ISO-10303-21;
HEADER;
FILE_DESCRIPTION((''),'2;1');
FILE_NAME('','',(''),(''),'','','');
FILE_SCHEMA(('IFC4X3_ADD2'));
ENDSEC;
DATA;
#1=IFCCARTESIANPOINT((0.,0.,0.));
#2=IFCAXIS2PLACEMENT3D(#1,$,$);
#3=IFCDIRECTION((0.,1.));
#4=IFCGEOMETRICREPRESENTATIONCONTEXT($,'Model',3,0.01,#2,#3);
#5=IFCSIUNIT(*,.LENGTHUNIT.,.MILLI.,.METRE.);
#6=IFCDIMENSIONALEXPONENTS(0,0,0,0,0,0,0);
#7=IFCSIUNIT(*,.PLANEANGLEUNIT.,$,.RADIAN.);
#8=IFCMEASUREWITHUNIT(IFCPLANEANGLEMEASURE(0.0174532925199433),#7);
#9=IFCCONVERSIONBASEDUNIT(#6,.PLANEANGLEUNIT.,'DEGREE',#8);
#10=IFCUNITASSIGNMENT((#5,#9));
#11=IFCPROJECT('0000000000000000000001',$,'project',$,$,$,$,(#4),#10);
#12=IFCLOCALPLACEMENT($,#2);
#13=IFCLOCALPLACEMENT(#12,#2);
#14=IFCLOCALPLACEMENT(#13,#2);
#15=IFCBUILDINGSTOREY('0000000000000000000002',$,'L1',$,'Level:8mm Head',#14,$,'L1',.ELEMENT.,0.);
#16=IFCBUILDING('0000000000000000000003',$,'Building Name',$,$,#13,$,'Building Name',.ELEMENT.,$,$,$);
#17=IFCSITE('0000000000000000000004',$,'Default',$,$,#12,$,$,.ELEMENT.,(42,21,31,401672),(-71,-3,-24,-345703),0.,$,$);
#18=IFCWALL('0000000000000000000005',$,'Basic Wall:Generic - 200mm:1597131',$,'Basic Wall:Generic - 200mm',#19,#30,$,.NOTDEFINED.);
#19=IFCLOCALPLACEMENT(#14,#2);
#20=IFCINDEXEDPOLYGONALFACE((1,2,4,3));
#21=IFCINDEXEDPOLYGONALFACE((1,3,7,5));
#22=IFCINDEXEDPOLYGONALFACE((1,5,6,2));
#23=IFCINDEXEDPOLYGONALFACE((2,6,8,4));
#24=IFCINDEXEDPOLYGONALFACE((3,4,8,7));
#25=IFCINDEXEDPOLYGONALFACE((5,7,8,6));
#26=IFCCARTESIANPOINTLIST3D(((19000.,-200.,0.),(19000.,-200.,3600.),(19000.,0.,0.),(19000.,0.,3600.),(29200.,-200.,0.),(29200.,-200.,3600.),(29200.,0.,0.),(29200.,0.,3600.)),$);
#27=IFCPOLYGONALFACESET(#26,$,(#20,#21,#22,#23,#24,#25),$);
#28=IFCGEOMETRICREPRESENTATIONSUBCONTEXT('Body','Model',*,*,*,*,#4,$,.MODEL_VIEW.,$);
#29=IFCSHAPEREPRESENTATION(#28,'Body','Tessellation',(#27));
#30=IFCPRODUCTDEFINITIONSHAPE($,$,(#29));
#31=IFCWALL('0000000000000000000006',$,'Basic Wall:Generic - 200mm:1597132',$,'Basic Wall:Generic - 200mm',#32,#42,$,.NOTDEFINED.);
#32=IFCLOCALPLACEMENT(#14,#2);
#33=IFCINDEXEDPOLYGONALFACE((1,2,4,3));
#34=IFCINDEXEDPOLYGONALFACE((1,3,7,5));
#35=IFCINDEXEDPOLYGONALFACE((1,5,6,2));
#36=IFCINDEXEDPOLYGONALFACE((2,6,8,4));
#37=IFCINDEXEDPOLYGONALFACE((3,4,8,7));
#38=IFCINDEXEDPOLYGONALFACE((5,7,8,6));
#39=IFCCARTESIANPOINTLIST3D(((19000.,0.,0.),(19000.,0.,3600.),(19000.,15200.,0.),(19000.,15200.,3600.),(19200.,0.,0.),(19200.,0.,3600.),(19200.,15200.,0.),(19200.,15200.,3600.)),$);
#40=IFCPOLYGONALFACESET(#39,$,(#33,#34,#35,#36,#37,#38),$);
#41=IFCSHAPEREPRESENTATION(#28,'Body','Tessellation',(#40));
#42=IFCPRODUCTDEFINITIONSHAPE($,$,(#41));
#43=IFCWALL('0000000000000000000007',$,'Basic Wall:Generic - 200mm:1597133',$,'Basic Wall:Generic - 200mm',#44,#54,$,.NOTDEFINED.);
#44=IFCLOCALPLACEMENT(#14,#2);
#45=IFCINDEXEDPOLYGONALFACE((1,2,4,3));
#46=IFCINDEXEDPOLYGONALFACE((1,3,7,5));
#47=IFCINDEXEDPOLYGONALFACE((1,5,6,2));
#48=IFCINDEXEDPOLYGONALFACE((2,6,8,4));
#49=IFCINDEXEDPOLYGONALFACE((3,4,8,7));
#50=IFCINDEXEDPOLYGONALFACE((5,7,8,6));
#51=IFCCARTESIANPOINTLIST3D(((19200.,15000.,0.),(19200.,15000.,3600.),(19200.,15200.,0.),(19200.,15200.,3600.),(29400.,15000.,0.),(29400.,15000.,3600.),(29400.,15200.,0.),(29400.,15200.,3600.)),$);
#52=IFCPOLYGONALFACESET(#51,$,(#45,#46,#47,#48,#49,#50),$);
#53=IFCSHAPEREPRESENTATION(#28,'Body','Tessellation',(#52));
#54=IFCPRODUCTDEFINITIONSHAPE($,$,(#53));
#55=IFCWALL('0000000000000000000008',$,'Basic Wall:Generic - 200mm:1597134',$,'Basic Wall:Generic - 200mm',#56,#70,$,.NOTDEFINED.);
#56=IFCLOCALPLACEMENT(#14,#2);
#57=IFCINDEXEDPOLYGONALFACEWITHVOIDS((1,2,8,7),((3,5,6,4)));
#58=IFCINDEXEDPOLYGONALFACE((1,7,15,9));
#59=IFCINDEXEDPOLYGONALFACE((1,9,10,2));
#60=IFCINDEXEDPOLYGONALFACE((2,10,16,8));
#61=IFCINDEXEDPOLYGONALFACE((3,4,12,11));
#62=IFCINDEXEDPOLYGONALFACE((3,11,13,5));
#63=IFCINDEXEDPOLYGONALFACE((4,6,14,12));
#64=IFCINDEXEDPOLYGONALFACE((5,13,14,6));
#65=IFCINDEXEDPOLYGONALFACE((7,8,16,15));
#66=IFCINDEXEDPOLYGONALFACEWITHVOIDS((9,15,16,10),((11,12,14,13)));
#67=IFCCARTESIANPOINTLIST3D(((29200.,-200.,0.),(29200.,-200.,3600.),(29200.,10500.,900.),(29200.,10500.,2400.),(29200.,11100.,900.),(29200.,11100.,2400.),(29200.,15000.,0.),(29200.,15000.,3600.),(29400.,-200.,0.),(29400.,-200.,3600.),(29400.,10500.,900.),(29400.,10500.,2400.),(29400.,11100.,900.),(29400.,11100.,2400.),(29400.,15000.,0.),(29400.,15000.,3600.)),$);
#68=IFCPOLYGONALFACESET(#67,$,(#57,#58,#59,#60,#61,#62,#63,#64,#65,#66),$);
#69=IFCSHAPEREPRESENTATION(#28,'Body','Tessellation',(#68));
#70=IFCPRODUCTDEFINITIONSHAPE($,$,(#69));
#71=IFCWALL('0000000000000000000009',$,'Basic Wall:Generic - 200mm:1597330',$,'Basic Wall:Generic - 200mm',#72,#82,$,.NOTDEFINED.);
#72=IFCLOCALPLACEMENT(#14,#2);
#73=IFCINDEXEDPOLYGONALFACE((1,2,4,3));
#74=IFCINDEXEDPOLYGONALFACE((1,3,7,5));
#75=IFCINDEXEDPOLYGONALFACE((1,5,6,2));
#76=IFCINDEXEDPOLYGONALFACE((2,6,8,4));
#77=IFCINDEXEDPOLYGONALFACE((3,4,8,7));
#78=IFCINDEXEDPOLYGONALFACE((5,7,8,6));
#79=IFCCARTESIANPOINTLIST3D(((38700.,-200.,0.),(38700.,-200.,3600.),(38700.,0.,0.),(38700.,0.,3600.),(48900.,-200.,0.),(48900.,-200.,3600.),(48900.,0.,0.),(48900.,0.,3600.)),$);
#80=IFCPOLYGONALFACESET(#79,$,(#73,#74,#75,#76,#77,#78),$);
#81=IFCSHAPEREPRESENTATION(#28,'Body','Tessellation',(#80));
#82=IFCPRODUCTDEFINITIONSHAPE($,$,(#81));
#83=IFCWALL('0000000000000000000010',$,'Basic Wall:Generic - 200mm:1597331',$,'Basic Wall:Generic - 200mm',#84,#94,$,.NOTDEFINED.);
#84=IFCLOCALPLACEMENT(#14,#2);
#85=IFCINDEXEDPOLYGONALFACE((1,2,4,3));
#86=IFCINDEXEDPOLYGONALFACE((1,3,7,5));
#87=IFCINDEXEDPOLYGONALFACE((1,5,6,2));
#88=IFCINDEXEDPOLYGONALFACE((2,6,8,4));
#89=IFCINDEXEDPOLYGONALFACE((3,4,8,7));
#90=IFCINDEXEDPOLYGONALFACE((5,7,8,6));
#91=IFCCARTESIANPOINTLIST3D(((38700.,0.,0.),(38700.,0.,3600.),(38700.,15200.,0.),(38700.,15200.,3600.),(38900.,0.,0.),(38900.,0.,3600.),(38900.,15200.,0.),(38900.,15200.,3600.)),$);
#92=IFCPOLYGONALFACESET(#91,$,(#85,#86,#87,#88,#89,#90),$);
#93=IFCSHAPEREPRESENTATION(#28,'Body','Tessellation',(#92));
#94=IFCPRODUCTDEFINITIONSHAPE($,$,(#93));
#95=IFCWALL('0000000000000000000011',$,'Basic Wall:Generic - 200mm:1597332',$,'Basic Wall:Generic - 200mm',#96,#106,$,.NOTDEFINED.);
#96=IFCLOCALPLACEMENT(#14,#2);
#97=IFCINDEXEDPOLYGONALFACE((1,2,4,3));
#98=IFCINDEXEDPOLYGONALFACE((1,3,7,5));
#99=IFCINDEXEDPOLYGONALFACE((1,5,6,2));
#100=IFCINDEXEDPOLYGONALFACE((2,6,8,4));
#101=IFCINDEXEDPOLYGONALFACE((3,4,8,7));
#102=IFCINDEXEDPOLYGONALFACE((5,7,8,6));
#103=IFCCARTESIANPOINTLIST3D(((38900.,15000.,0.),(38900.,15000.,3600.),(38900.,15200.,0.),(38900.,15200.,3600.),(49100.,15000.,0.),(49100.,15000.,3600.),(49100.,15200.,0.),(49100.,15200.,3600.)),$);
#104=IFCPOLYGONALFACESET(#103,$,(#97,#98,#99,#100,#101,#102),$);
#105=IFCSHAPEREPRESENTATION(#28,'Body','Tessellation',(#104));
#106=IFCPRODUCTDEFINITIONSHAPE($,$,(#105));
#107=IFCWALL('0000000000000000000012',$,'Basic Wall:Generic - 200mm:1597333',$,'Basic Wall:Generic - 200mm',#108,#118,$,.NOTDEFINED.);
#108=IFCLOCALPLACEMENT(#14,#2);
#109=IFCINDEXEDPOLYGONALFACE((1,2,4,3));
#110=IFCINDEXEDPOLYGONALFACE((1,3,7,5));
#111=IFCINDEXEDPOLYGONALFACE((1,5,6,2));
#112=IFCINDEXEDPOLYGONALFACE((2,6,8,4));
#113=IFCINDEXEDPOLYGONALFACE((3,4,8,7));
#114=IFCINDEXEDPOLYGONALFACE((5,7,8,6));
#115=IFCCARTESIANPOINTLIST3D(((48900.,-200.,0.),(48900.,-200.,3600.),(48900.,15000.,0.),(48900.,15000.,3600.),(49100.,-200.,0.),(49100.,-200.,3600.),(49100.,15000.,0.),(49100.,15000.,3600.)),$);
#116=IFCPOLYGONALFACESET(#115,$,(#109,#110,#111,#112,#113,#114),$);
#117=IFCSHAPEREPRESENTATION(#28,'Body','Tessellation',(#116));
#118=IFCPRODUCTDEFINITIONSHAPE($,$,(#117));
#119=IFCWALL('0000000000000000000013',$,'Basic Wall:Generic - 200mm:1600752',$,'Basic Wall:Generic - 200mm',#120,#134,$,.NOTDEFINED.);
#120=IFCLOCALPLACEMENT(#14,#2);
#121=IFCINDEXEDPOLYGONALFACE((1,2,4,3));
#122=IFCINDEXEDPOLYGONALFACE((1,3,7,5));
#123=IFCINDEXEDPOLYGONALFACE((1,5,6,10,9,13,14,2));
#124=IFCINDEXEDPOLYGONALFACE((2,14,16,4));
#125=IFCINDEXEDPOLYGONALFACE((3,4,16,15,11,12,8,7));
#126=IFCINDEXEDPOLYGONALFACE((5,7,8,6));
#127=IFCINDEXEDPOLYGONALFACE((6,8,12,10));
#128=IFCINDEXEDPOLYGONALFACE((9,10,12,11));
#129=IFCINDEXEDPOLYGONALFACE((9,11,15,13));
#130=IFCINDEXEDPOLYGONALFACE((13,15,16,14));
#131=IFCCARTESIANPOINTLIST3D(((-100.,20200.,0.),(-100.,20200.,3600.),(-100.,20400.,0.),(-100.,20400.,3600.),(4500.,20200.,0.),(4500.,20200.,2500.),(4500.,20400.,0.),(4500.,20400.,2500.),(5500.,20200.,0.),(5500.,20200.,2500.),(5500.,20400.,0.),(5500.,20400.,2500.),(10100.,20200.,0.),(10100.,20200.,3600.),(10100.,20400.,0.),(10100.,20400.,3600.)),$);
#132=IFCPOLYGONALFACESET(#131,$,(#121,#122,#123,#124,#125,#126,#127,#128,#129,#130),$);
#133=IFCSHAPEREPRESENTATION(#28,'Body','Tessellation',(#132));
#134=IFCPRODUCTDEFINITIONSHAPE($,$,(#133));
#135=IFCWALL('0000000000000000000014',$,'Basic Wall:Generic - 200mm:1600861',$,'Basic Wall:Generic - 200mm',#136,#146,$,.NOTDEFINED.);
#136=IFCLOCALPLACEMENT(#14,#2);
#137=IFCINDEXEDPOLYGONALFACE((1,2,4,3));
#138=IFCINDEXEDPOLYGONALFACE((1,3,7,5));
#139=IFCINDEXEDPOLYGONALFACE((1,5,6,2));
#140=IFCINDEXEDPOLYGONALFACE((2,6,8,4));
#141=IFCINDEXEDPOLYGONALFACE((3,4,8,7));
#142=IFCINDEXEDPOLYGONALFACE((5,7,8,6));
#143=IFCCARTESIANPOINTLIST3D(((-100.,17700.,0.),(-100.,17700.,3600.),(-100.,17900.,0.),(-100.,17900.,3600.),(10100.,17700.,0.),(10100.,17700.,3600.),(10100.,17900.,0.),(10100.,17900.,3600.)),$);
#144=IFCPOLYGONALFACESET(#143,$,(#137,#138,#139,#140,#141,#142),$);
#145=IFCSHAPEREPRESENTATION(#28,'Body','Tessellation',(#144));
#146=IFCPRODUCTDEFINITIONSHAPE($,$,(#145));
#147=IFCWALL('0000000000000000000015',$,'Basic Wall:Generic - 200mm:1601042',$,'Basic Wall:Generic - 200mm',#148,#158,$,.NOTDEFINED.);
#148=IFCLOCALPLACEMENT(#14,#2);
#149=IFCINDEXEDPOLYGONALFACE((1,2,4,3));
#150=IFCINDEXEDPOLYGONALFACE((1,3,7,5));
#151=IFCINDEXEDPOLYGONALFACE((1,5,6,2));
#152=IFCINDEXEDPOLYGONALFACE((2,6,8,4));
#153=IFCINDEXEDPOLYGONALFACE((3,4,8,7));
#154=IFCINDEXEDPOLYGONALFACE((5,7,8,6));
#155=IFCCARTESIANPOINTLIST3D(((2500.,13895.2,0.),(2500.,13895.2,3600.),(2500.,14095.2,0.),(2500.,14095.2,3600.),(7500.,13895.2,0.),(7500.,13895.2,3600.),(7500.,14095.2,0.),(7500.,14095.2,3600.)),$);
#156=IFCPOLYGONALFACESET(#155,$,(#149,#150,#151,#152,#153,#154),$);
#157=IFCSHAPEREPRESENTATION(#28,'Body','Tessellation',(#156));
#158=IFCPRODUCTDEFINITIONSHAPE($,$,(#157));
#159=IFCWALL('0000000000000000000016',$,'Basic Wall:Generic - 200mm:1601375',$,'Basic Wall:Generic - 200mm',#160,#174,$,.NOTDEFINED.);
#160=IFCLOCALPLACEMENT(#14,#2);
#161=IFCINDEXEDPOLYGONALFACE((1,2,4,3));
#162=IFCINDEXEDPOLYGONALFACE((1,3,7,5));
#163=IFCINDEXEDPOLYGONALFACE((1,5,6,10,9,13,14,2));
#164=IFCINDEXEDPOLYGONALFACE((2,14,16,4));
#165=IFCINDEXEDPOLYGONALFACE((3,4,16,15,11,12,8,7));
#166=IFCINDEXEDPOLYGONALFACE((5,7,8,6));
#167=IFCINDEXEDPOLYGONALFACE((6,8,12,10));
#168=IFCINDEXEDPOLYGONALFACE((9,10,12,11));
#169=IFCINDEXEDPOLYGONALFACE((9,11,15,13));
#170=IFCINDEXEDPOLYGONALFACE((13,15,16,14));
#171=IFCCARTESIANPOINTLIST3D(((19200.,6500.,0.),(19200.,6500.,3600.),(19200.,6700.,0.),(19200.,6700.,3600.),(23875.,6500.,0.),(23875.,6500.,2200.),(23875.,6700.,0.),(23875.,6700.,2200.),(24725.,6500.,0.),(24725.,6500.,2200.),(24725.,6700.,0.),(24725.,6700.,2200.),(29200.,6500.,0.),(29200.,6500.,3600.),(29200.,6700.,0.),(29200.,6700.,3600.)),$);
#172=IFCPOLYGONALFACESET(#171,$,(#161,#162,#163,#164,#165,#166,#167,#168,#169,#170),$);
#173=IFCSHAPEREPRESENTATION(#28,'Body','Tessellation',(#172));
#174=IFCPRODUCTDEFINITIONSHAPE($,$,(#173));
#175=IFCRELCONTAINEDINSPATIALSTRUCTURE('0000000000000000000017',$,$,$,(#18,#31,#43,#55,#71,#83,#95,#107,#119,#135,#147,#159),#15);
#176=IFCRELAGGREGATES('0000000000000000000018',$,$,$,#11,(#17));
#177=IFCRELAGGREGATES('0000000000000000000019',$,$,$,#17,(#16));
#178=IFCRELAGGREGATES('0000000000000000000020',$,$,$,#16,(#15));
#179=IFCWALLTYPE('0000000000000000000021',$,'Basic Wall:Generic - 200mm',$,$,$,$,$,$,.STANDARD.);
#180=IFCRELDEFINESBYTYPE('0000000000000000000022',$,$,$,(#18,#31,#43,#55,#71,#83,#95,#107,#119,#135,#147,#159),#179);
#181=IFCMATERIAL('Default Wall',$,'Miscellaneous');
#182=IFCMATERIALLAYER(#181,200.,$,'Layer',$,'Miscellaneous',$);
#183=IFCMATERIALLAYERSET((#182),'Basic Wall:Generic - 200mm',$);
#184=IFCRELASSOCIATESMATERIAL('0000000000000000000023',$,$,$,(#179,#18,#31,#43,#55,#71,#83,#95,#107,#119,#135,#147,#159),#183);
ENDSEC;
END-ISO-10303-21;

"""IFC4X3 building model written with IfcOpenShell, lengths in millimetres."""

from ifc_helpers import new_model, entity, si_unit, converted_unit, direction, frame, frame_2d, origin, origin_2d_with_axis, place, context, subcontext, project, spatial, rectangle, extrude, material, layer, layer_set, type_object, element, save


model = new_model("IFC4X3")

# Units and contexts
model_context = context("Model", 3, precision=0.01, world=origin(), true_north=direction((0.0, 1.0)))
body_context = subcontext(model_context, "Body", "Model", "MODEL_VIEW")
ifc_project = project(units=[si_unit("LENGTHUNIT", "METRE", prefix="MILLI"), converted_unit("PLANEANGLEUNIT", "DEGREE", entity("IfcPlaneAngleMeasure", 0.0174532925199433), si_unit("PLANEANGLEUNIT", "RADIAN"), dimensions=[0, 0, 0, 0, 0, 0, 0])], contexts=[model_context])

# Site, building, storey
site_placement = place(None, origin())
site = spatial("IfcSite", under=ifc_project, at=site_placement, Name="Default", CompositionType="ELEMENT", RefLatitude=(42, 21, 31, 401672), RefLongitude=(-71, -3, -24, -345703), RefElevation=0.0)
building_placement = place(site_placement, origin())
building = spatial("IfcBuilding", under=site, at=building_placement, Name="Building Name", LongName="Building Name", CompositionType="ELEMENT")
storey_placement = place(building_placement, origin())
storey = spatial("IfcBuildingStorey", under=building, at=storey_placement, Name="L1", ObjectType="Level:8mm Head", LongName="L1", CompositionType="ELEMENT", Elevation=0.0)

# Walls
ifc_material_1 = material(Name="Default Wall", Category="Miscellaneous")
ifc_layer_1 = layer(ifc_material_1, 200.0, Name="Layer", Category="Miscellaneous")
ifc_layer_set_1 = layer_set([ifc_layer_1], Name="Basic Wall:Generic - 200mm")
wall_type_1 = type_object("IfcWallType", Name="Basic Wall:Generic - 200mm", PredefinedType="STANDARD", material=ifc_layer_set_1)
wall_1_placement = place(storey_placement, frame((19000.0, -100.0, 0.0)))
element("IfcWall", 1, at=wall_1_placement, inside=storey, type_object=wall_type_1, material=ifc_layer_set_1, Name="Basic Wall:Generic - 200mm:1597131", ObjectType="Basic Wall:Generic - 200mm", PredefinedType="NOTDEFINED", context=body_context, shape_type="SweptSolid", body=[
    extrude(rectangle(XDim=10200.0, YDim=200.0, at=frame_2d((5100.0, 0.0), x_axis=(-1.0, 0.0))), origin(), (0.0, 0.0, 1.0), 3600.0),
])
wall_2_placement = place(storey_placement, frame((19100.0, 15200.0, 0.0), z_axis=(0.0, 0.0, 1.0), x_axis=(0.0, -1.0, 0.0)))
element("IfcWall", 2, at=wall_2_placement, inside=storey, type_object=wall_type_1, material=ifc_layer_set_1, Name="Basic Wall:Generic - 200mm:1597132", ObjectType="Basic Wall:Generic - 200mm", PredefinedType="NOTDEFINED", context=body_context, shape_type="SweptSolid", body=[
    extrude(rectangle(XDim=15200.0, YDim=200.0, at=frame_2d((7600.0, 0.0), x_axis=(-1.0, 0.0))), origin(), (0.0, 0.0, 1.0), 3600.0),
])
wall_3_placement = place(storey_placement, frame((29400.0, 15100.0, 0.0), z_axis=(0.0, 0.0, 1.0), x_axis=(-1.0, 0.0, 0.0)))
element("IfcWall", 3, at=wall_3_placement, inside=storey, type_object=wall_type_1, material=ifc_layer_set_1, Name="Basic Wall:Generic - 200mm:1597133", ObjectType="Basic Wall:Generic - 200mm", PredefinedType="NOTDEFINED", context=body_context, shape_type="SweptSolid", body=[
    extrude(rectangle(XDim=10200.0, YDim=200.0, at=frame_2d((5100.0, 0.0), x_axis=(-1.0, 0.0))), origin(), (0.0, 0.0, 1.0), 3600.0),
])

# Wall, opening
wall_4_placement = place(storey_placement, frame((29300.0, -200.0, 0.0), z_axis=(0.0, 0.0, 1.0), x_axis=(0.0, 1.0, 0.0)))
wall_4 = element("IfcWall", 4, at=wall_4_placement, inside=storey, type_object=wall_type_1, material=ifc_layer_set_1, Name="Basic Wall:Generic - 200mm:1597134", ObjectType="Basic Wall:Generic - 200mm", PredefinedType="NOTDEFINED", context=body_context, shape_type="SweptSolid", body=[
    extrude(rectangle(XDim=15200.0, YDim=200.0, at=frame_2d((7600.0, 0.0), x_axis=(-1.0, 0.0))), origin(), (0.0, 0.0, 1.0), 3600.0),
])
opening_1_placement = place(wall_4_placement, frame((11300.0, 100.0, 900.0)))
element("IfcOpeningElement", 5, at=opening_1_placement, cuts=wall_4, PredefinedType="OPENING", context=body_context, shape_type="SweptSolid", body=[
    extrude(rectangle(XDim=1500.0, YDim=600.0, at=frame_2d((750.0, 300.0), x_axis=(-1.0, 0.0))), frame((0.0, 0.0, 0.0), z_axis=(0.0, -1.0, 0.0), x_axis=(0.0, 0.0, 1.0)), (0.0, 0.0, 1.0), 200.0),
])

# Walls
wall_5_placement = place(storey_placement, frame((38700.0, -100.0, 0.0)))
element("IfcWall", 6, at=wall_5_placement, inside=storey, type_object=wall_type_1, material=ifc_layer_set_1, Name="Basic Wall:Generic - 200mm:1597330", ObjectType="Basic Wall:Generic - 200mm", PredefinedType="NOTDEFINED", context=body_context, shape_type="SweptSolid", body=[
    extrude(rectangle(XDim=10200.0, YDim=200.0, at=frame_2d((5100.0, 0.0), x_axis=(-1.0, 0.0))), origin(), (0.0, 0.0, 1.0), 3600.0),
])
wall_6_placement = place(storey_placement, frame((38800.0, 15200.0, 0.0), z_axis=(0.0, 0.0, 1.0), x_axis=(0.0, -1.0, 0.0)))
element("IfcWall", 7, at=wall_6_placement, inside=storey, type_object=wall_type_1, material=ifc_layer_set_1, Name="Basic Wall:Generic - 200mm:1597331", ObjectType="Basic Wall:Generic - 200mm", PredefinedType="NOTDEFINED", context=body_context, shape_type="SweptSolid", body=[
    extrude(rectangle(XDim=15200.0, YDim=200.0, at=frame_2d((7600.0, 0.0), x_axis=(-1.0, 0.0))), origin(), (0.0, 0.0, 1.0), 3600.0),
])
wall_7_placement = place(storey_placement, frame((49100.0, 15100.0, 0.0), z_axis=(0.0, 0.0, 1.0), x_axis=(-1.0, 0.0, 0.0)))
element("IfcWall", 8, at=wall_7_placement, inside=storey, type_object=wall_type_1, material=ifc_layer_set_1, Name="Basic Wall:Generic - 200mm:1597332", ObjectType="Basic Wall:Generic - 200mm", PredefinedType="NOTDEFINED", context=body_context, shape_type="SweptSolid", body=[
    extrude(rectangle(XDim=10200.0, YDim=200.0, at=frame_2d((5100.0, 0.0), x_axis=(-1.0, 0.0))), origin(), (0.0, 0.0, 1.0), 3600.0),
])
wall_8_placement = place(storey_placement, frame((49000.0, -200.0, 0.0), z_axis=(0.0, 0.0, 1.0), x_axis=(0.0, 1.0, 0.0)))
element("IfcWall", 9, at=wall_8_placement, inside=storey, type_object=wall_type_1, material=ifc_layer_set_1, Name="Basic Wall:Generic - 200mm:1597333", ObjectType="Basic Wall:Generic - 200mm", PredefinedType="NOTDEFINED", context=body_context, shape_type="SweptSolid", body=[
    extrude(rectangle(XDim=15200.0, YDim=200.0, at=frame_2d((7600.0, 0.0), x_axis=(-1.0, 0.0))), origin(), (0.0, 0.0, 1.0), 3600.0),
])

# Wall, opening
wall_9_placement = place(storey_placement, frame((10100.0, 20300.0, 0.0), z_axis=(0.0, 0.0, 1.0), x_axis=(-1.0, 0.0, 0.0)))
wall_9 = element("IfcWall", 10, at=wall_9_placement, inside=storey, type_object=wall_type_1, material=ifc_layer_set_1, Name="Basic Wall:Generic - 200mm:1600752", ObjectType="Basic Wall:Generic - 200mm", PredefinedType="NOTDEFINED", context=body_context, shape_type="SweptSolid", body=[
    extrude(rectangle(XDim=10200.0, YDim=200.0, at=frame_2d((5100.0, 0.0), x_axis=(1.0, 0.0))), origin(), (0.0, 0.0, 1.0), 3600.0),
])
opening_2_placement = place(wall_9_placement, frame((5600.0, 100.0, 0.0)))
element("IfcOpeningElement", 11, at=opening_2_placement, cuts=wall_9, PredefinedType="OPENING", context=body_context, shape_type="SweptSolid", body=[
    extrude(rectangle(XDim=2500.0, YDim=1000.0, at=origin_2d_with_axis()), frame((-500.0, -200.0, 1250.0), z_axis=(0.0, 1.0, 0.0), x_axis=(0.0, 0.0, -1.0)), (0.0, 0.0, 1.0), 200.0),
])

# Walls
wall_10_placement = place(storey_placement, frame((10100.0, 17800.0, 0.0), z_axis=(0.0, 0.0, 1.0), x_axis=(-1.0, 0.0, 0.0)))
element("IfcWall", 12, at=wall_10_placement, inside=storey, type_object=wall_type_1, material=ifc_layer_set_1, Name="Basic Wall:Generic - 200mm:1600861", ObjectType="Basic Wall:Generic - 200mm", PredefinedType="NOTDEFINED", context=body_context, shape_type="SweptSolid", body=[
    extrude(rectangle(XDim=10200.0, YDim=200.0, at=frame_2d((5100.0, 0.0), x_axis=(-1.0, 0.0))), origin(), (0.0, 0.0, 1.0), 3600.0),
])
wall_11_placement = place(storey_placement, frame((7500.0, 13995.2, 0.0), z_axis=(0.0, 0.0, 1.0), x_axis=(-1.0, 0.0, 0.0)))
element("IfcWall", 13, at=wall_11_placement, inside=storey, type_object=wall_type_1, material=ifc_layer_set_1, Name="Basic Wall:Generic - 200mm:1601042", ObjectType="Basic Wall:Generic - 200mm", PredefinedType="NOTDEFINED", context=body_context, shape_type="SweptSolid", body=[
    extrude(rectangle(XDim=5000.0, YDim=200.0, at=frame_2d((2500.0, 0.0), x_axis=(-1.0, 0.0))), origin(), (0.0, 0.0, 1.0), 3600.0),
])

# Wall, opening
wall_12_placement = place(storey_placement, frame((29200.0, 6600.0, 0.0), z_axis=(0.0, 0.0, 1.0), x_axis=(-1.0, 0.0, 0.0)))
wall_12 = element("IfcWall", 14, at=wall_12_placement, inside=storey, type_object=wall_type_1, material=ifc_layer_set_1, Name="Basic Wall:Generic - 200mm:1601375", ObjectType="Basic Wall:Generic - 200mm", PredefinedType="NOTDEFINED", context=body_context, shape_type="SweptSolid", body=[
    extrude(rectangle(XDim=10000.0, YDim=200.0, at=frame_2d((5000.0, 0.0), x_axis=(1.0, 0.0))), origin(), (0.0, 0.0, 1.0), 3600.0),
])
opening_3_placement = place(wall_12_placement, frame((5325.0, 100.0, 0.0)))
element("IfcOpeningElement", 15, at=opening_3_placement, cuts=wall_12, PredefinedType="OPENING", context=body_context, shape_type="SweptSolid", body=[
    extrude(rectangle(XDim=2200.0, YDim=850.0, at=frame_2d((1100.0, 425.0), x_axis=(1.0, 0.0))), frame((0.0, 0.0, 0.0), z_axis=(0.0, -1.0, 0.0), x_axis=(0.0, 0.0, 1.0)), (0.0, 0.0, 1.0), 200.0),
])

save(model, "model.ifc")
